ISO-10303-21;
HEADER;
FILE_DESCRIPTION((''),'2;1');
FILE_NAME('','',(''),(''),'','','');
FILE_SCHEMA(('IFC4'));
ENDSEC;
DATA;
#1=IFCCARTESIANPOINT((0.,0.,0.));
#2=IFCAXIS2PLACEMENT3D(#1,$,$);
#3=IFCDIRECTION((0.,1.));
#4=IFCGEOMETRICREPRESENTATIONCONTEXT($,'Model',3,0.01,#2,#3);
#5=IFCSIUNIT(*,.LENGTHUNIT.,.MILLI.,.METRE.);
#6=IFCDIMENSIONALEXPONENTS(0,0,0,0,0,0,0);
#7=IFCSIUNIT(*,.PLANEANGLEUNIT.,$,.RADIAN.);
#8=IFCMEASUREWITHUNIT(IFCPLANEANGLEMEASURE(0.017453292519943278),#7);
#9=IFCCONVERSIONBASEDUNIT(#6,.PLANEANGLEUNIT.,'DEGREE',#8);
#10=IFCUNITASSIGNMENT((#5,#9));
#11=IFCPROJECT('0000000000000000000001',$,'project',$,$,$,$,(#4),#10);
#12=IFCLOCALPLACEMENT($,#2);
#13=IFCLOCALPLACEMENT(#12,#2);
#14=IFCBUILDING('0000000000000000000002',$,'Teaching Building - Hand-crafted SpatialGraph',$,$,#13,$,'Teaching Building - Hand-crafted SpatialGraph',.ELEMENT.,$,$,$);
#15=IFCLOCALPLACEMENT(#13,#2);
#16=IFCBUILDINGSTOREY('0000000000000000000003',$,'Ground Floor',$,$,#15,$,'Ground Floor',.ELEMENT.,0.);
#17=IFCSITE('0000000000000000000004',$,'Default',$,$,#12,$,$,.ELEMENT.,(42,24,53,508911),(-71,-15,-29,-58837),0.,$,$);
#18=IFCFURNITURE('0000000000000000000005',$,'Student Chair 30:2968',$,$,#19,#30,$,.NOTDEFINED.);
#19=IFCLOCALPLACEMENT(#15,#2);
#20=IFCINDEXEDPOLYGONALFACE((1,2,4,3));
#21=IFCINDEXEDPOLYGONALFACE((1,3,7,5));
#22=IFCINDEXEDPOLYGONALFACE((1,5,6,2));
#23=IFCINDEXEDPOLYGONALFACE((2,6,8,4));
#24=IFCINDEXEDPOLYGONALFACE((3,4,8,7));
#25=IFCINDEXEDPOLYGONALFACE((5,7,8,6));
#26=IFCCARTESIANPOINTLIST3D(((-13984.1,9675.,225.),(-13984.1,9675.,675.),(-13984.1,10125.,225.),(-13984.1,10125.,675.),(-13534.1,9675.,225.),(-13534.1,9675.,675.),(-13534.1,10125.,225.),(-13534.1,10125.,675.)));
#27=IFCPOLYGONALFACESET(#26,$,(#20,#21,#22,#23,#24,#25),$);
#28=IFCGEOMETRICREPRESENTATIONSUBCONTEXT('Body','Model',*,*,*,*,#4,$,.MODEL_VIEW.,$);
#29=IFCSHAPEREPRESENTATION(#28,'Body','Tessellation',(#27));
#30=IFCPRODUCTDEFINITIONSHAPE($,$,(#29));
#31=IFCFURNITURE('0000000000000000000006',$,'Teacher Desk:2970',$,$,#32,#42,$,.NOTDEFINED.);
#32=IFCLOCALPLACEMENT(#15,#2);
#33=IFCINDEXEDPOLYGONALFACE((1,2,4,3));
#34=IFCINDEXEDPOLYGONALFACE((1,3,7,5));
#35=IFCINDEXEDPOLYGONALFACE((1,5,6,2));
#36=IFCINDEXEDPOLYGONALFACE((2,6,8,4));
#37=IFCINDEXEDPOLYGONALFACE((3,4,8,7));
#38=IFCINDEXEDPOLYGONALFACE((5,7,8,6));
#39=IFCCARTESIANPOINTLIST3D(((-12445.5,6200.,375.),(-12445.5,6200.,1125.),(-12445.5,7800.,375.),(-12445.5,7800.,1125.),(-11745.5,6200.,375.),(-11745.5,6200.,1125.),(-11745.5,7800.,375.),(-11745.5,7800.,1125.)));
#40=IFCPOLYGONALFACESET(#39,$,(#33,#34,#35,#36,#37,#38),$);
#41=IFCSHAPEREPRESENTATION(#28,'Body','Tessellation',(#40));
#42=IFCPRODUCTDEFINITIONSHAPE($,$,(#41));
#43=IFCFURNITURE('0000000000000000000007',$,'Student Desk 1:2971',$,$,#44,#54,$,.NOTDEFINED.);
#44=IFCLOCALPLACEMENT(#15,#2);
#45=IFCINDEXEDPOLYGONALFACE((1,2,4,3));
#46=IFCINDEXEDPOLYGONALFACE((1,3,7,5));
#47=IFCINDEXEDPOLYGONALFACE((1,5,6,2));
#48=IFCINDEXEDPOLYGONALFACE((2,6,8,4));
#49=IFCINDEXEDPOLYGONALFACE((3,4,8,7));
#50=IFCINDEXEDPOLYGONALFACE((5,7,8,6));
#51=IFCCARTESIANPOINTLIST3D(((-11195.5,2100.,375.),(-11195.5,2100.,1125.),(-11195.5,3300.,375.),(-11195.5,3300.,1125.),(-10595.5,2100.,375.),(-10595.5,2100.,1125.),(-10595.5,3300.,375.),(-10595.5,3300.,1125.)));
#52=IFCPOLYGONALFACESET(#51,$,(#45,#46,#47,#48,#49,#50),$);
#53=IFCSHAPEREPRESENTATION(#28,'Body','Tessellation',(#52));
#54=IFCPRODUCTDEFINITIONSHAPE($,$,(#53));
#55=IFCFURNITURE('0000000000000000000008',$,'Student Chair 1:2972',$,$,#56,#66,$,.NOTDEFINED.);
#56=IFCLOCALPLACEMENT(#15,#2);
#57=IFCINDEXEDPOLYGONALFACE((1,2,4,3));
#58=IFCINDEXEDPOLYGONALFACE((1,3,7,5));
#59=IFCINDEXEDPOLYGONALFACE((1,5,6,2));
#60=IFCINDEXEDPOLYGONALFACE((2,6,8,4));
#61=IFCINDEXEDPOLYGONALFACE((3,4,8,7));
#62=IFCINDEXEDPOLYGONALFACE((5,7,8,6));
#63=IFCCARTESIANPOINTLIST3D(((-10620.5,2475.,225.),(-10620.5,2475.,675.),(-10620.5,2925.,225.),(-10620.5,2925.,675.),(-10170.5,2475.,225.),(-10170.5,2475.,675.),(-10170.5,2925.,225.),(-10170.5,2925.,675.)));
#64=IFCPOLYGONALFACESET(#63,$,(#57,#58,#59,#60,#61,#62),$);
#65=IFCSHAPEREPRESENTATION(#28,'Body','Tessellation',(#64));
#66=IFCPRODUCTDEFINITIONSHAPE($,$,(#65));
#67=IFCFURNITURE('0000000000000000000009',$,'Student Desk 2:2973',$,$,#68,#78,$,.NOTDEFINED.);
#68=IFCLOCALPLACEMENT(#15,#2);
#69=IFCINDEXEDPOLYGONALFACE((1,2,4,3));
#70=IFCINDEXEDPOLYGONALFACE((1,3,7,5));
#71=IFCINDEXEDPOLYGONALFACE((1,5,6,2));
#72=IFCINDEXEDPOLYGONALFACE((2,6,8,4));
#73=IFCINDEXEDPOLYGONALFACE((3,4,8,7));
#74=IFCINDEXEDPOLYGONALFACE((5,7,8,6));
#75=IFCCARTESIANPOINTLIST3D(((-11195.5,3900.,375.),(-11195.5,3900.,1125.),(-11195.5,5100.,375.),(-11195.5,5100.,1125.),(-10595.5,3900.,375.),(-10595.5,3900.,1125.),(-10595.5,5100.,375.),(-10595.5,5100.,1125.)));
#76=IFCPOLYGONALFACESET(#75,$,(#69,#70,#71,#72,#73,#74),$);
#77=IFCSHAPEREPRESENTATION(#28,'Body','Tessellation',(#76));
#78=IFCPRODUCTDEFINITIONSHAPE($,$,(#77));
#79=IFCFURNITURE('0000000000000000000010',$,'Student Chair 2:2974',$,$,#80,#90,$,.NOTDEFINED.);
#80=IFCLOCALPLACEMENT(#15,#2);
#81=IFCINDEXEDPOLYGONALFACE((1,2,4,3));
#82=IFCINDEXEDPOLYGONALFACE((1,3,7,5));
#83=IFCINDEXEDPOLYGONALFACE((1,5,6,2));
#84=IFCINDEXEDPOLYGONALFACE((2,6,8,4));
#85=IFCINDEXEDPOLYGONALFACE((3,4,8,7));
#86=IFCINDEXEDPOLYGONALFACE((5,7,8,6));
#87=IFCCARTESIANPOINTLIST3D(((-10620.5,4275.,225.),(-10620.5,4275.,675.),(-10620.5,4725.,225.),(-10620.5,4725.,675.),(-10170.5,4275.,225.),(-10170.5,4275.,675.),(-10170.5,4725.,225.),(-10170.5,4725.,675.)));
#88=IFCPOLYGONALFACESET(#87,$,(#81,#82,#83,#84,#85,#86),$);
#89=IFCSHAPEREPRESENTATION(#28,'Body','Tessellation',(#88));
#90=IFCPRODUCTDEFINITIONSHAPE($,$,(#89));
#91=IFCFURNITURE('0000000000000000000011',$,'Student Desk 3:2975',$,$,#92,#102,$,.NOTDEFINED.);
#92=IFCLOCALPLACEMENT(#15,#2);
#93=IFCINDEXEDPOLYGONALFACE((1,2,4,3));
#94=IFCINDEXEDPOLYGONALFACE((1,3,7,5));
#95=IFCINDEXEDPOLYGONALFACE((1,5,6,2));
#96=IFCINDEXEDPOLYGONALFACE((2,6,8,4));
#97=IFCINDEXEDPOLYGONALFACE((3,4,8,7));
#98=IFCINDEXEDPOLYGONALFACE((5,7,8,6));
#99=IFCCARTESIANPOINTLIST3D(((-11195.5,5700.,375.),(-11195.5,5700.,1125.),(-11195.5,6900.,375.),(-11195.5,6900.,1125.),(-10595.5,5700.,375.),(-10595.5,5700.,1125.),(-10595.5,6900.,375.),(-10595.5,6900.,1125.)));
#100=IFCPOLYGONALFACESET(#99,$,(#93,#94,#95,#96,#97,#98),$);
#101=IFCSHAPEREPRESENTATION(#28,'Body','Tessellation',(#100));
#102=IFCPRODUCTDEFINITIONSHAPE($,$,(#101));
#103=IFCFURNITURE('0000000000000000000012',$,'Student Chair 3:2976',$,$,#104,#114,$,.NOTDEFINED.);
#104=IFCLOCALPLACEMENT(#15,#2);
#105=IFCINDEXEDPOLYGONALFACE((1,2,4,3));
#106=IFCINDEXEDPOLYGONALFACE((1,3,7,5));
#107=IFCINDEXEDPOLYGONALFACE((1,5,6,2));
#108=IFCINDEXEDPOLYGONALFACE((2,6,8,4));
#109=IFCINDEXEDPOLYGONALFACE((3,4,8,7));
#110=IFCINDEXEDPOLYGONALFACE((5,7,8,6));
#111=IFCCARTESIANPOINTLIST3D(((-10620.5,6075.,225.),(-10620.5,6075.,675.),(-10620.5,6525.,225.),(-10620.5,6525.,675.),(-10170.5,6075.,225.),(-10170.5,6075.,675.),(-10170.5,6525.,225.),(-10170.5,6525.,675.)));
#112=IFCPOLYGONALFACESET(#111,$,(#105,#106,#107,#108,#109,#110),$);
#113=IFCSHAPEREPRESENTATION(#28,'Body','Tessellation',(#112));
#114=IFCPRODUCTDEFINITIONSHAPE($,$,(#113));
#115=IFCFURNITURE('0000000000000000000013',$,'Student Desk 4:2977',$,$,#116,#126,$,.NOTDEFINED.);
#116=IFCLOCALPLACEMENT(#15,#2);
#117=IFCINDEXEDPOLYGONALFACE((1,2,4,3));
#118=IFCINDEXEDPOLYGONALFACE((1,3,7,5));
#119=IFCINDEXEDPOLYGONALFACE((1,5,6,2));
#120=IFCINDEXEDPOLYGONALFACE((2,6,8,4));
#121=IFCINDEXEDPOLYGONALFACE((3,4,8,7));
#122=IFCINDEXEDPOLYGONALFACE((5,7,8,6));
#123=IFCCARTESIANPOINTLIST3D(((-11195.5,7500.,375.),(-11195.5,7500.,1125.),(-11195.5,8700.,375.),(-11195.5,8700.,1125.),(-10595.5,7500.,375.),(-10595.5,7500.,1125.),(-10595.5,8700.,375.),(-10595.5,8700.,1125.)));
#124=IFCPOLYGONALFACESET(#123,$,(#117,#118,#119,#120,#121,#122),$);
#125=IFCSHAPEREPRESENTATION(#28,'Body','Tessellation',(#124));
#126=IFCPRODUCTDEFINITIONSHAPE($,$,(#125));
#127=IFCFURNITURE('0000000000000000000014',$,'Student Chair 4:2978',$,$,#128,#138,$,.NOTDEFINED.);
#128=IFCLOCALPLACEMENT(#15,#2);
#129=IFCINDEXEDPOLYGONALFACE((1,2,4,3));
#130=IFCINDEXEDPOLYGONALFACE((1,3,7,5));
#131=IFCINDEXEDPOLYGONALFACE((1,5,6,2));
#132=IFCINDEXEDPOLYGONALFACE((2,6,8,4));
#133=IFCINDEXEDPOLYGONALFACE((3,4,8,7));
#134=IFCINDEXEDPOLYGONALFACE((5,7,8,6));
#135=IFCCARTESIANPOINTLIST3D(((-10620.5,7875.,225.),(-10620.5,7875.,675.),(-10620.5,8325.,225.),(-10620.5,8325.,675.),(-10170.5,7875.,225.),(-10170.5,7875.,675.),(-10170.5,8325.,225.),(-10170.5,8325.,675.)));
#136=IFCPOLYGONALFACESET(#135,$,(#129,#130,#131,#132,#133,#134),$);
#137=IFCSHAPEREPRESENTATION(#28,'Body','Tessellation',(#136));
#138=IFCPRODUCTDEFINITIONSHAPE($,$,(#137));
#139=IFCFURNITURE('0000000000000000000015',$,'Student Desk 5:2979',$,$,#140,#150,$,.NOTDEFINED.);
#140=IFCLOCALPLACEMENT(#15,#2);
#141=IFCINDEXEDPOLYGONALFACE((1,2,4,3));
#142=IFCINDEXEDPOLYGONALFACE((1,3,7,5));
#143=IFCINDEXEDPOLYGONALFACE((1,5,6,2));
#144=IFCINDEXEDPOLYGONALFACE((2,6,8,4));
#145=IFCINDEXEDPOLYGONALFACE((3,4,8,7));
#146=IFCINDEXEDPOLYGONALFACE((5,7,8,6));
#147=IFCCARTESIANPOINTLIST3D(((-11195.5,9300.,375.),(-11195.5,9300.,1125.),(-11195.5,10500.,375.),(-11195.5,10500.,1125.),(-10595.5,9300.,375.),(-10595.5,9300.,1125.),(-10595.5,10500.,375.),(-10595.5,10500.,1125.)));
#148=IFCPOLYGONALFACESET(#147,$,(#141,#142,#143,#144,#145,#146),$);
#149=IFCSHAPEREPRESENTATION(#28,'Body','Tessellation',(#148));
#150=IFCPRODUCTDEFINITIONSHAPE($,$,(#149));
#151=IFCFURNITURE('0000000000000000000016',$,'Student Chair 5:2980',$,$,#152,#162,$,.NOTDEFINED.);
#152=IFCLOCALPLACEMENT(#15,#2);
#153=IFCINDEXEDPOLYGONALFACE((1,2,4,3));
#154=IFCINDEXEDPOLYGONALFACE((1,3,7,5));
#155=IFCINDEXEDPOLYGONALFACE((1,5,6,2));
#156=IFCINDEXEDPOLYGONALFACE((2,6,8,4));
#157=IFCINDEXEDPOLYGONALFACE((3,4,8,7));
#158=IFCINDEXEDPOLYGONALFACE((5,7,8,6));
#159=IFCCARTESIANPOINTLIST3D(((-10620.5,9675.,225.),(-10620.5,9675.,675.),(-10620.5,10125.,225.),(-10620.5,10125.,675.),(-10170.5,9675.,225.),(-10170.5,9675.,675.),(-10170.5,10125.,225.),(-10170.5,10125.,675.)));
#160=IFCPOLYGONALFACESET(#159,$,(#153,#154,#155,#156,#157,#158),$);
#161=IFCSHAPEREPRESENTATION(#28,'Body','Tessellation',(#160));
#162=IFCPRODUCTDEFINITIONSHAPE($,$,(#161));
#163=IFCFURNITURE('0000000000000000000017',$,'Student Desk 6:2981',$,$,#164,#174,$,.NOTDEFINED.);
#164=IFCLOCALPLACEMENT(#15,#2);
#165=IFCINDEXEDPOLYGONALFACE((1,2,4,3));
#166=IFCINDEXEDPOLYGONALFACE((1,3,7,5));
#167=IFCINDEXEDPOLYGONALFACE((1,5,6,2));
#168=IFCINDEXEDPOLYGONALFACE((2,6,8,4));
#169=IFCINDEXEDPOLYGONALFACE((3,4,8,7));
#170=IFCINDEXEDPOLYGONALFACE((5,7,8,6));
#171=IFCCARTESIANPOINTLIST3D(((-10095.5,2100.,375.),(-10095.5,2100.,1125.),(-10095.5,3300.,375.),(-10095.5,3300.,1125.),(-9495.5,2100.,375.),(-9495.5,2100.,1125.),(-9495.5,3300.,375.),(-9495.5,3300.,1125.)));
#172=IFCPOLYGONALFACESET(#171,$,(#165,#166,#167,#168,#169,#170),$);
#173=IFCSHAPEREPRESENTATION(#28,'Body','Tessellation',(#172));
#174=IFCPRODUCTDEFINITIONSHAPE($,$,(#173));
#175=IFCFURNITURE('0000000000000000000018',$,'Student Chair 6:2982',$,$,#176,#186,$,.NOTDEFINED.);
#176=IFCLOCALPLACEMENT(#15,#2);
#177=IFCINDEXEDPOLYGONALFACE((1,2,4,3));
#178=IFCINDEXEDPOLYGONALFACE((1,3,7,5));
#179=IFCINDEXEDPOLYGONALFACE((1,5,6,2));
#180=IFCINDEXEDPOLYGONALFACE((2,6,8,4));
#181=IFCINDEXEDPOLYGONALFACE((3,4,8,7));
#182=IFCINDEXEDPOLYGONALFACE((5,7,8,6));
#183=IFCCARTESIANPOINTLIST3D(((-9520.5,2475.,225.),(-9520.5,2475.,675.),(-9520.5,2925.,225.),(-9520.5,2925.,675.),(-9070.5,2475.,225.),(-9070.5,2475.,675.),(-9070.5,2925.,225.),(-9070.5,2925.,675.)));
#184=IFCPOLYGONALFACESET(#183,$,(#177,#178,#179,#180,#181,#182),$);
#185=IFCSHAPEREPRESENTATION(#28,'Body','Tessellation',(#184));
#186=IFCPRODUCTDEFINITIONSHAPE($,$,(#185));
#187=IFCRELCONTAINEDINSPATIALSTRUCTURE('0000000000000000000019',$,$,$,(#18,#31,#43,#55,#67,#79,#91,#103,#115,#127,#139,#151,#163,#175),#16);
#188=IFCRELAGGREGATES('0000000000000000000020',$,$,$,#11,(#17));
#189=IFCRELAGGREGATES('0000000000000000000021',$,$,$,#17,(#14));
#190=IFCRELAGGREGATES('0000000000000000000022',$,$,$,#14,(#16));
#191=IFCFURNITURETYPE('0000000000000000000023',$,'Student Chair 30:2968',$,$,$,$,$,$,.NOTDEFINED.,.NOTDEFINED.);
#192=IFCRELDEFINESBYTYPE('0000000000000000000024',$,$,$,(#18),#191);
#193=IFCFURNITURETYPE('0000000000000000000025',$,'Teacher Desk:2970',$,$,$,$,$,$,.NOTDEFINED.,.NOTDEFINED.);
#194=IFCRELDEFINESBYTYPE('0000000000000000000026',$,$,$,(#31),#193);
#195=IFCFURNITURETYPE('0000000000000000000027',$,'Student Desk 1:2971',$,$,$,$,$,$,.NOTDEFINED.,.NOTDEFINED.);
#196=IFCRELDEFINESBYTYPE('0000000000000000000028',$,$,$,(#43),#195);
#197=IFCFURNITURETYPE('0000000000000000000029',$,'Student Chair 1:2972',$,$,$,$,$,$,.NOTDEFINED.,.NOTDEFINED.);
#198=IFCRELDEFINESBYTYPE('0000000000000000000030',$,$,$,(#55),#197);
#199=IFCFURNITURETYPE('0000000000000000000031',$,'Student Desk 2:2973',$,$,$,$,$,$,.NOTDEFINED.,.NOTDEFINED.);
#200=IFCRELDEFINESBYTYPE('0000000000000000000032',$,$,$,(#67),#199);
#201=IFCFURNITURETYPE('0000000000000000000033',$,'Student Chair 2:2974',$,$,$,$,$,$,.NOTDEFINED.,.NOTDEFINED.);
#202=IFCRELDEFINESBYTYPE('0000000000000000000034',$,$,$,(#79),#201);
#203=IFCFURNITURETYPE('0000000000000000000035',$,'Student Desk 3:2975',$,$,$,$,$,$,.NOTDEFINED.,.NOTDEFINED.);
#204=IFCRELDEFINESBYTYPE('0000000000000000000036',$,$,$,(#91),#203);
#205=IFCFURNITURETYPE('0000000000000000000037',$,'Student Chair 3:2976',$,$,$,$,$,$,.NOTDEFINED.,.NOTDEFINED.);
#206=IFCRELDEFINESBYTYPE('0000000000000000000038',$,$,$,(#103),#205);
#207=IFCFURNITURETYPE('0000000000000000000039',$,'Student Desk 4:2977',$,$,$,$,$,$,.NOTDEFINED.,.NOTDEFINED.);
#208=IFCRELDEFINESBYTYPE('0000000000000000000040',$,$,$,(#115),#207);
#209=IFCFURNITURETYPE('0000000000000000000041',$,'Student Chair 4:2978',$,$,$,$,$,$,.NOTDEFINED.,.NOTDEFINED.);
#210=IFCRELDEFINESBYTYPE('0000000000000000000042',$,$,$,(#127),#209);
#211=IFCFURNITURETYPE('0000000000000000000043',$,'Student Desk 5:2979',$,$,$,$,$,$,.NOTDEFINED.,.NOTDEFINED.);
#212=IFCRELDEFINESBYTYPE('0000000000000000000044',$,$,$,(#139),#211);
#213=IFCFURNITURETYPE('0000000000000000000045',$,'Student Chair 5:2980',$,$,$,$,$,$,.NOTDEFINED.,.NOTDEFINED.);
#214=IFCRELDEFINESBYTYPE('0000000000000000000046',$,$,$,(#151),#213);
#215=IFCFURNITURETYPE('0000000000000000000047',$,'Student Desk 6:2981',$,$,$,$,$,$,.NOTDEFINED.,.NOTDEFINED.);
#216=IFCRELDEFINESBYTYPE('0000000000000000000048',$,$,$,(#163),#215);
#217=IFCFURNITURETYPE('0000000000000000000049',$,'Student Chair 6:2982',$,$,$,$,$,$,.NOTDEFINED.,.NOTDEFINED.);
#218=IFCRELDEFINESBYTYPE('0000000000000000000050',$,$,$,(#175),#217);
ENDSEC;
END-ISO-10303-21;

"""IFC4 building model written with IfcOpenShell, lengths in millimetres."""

from ifc_helpers import new_model, entity, si_unit, converted_unit, direction, frame, frame_2d, origin, origin_2d_with_axis, place, context, subcontext, project, spatial, rectangle, extrude, type_object, element, save


model = new_model("IFC4")

# Units and contexts
model_context = context("Model", 3, precision=0.01, world=origin(), true_north=direction((0.0, 1.0)))
body_context = subcontext(model_context, "Body", "Model", "MODEL_VIEW")
ifc_project = project(units=[si_unit("LENGTHUNIT", "METRE", prefix="MILLI"), converted_unit("PLANEANGLEUNIT", "DEGREE", entity("IfcPlaneAngleMeasure", 0.017453292519943278), si_unit("PLANEANGLEUNIT", "RADIAN"), dimensions=[0, 0, 0, 0, 0, 0, 0])], contexts=[model_context])

# Site, building, storey
site_placement = place(None, origin())
site = spatial("IfcSite", under=ifc_project, at=site_placement, Name="Default", CompositionType="ELEMENT", RefLatitude=(42, 24, 53, 508911), RefLongitude=(-71, -15, -29, -58837), RefElevation=0.0)
building_placement = place(site_placement, origin())
building = spatial("IfcBuilding", under=site, at=building_placement, Name="Teaching Building - Hand-crafted SpatialGraph", LongName="Teaching Building - Hand-crafted SpatialGraph", CompositionType="ELEMENT")
storey_placement = place(building_placement, origin())
storey = spatial("IfcBuildingStorey", under=building, at=storey_placement, Name="Ground Floor", LongName="Ground Floor", CompositionType="ELEMENT", Elevation=0.0)

# Furniture
furniture_type_1 = type_object("IfcFurnitureType", Name="Student Chair 30:2968", PredefinedType="NOTDEFINED")
furniture_1_placement = place(storey_placement, origin())
element("IfcFurniture", 1, at=furniture_1_placement, inside=storey, type_object=furniture_type_1, Name="Student Chair 30:2968", PredefinedType="NOTDEFINED", context=body_context, shape_type="SweptSolid", body=[
    extrude(rectangle(XDim=450.0, YDim=450.0, at=frame_2d((0.0, 0.0), x_axis=(1.0, 0.0))), frame((-13759.1, 9900.0, 225.0)), (0.0, 0.0, 1.0), 450.0),
])
furniture_type_2 = type_object("IfcFurnitureType", Name="Teacher Desk:2970", PredefinedType="NOTDEFINED")
furniture_2_placement = place(storey_placement, origin())
element("IfcFurniture", 2, at=furniture_2_placement, inside=storey, type_object=furniture_type_2, Name="Teacher Desk:2970", PredefinedType="NOTDEFINED", context=body_context, shape_type="SweptSolid", body=[
    extrude(rectangle(XDim=1600.0, YDim=700.0, at=origin_2d_with_axis()), frame((-12095.5, 7000.0, 375.0), z_axis=(0.0, 0.0, 1.0), x_axis=(0.0, 1.0, 0.0)), (0.0, 0.0, 1.0), 750.0),
])
furniture_type_3 = type_object("IfcFurnitureType", Name="Student Desk 1:2971", PredefinedType="NOTDEFINED")
furniture_3_placement = place(storey_placement, origin())
element("IfcFurniture", 3, at=furniture_3_placement, inside=storey, type_object=furniture_type_3, Name="Student Desk 1:2971", PredefinedType="NOTDEFINED", context=body_context, shape_type="SweptSolid", body=[
    extrude(rectangle(XDim=1200.0, YDim=600.0, at=origin_2d_with_axis()), frame((-10895.5, 2700.0, 375.0), z_axis=(0.0, 0.0, 1.0), x_axis=(0.0, 1.0, 0.0)), (0.0, 0.0, 1.0), 750.0),
])
furniture_type_4 = type_object("IfcFurnitureType", Name="Student Chair 1:2972", PredefinedType="NOTDEFINED")
furniture_4_placement = place(storey_placement, origin())
element("IfcFurniture", 4, at=furniture_4_placement, inside=storey, type_object=furniture_type_4, Name="Student Chair 1:2972", PredefinedType="NOTDEFINED", context=body_context, shape_type="SweptSolid", body=[
    extrude(rectangle(XDim=450.0, YDim=450.0, at=origin_2d_with_axis()), frame((-10395.5, 2700.0, 225.0)), (0.0, 0.0, 1.0), 450.0),
])
furniture_type_5 = type_object("IfcFurnitureType", Name="Student Desk 2:2973", PredefinedType="NOTDEFINED")
furniture_5_placement = place(storey_placement, origin())
element("IfcFurniture", 5, at=furniture_5_placement, inside=storey, type_object=furniture_type_5, Name="Student Desk 2:2973", PredefinedType="NOTDEFINED", context=body_context, shape_type="SweptSolid", body=[
    extrude(rectangle(XDim=1200.0, YDim=600.0, at=frame_2d((0.0, 0.0), x_axis=(1.0, 0.0))), frame((-10895.5, 4500.0, 375.0), z_axis=(0.0, 0.0, 1.0), x_axis=(0.0, 1.0, 0.0)), (0.0, 0.0, 1.0), 750.0),
])
furniture_type_6 = type_object("IfcFurnitureType", Name="Student Chair 2:2974", PredefinedType="NOTDEFINED")
furniture_6_placement = place(storey_placement, origin())
element("IfcFurniture", 6, at=furniture_6_placement, inside=storey, type_object=furniture_type_6, Name="Student Chair 2:2974", PredefinedType="NOTDEFINED", context=body_context, shape_type="SweptSolid", body=[
    extrude(rectangle(XDim=450.0, YDim=450.0, at=origin_2d_with_axis()), frame((-10395.5, 4500.0, 225.0)), (0.0, 0.0, 1.0), 450.0),
])
furniture_type_7 = type_object("IfcFurnitureType", Name="Student Desk 3:2975", PredefinedType="NOTDEFINED")
furniture_7_placement = place(storey_placement, origin())
element("IfcFurniture", 7, at=furniture_7_placement, inside=storey, type_object=furniture_type_7, Name="Student Desk 3:2975", PredefinedType="NOTDEFINED", context=body_context, shape_type="SweptSolid", body=[
    extrude(rectangle(XDim=1200.0, YDim=600.0, at=origin_2d_with_axis()), frame((-10895.5, 6300.0, 375.0), z_axis=(0.0, 0.0, 1.0), x_axis=(0.0, 1.0, 0.0)), (0.0, 0.0, 1.0), 750.0),
])
furniture_type_8 = type_object("IfcFurnitureType", Name="Student Chair 3:2976", PredefinedType="NOTDEFINED")
furniture_8_placement = place(storey_placement, origin())
element("IfcFurniture", 8, at=furniture_8_placement, inside=storey, type_object=furniture_type_8, Name="Student Chair 3:2976", PredefinedType="NOTDEFINED", context=body_context, shape_type="SweptSolid", body=[
    extrude(rectangle(XDim=450.0, YDim=450.0, at=origin_2d_with_axis()), frame((-10395.5, 6300.0, 225.0)), (0.0, 0.0, 1.0), 450.0),
])
furniture_type_9 = type_object("IfcFurnitureType", Name="Student Desk 4:2977", PredefinedType="NOTDEFINED")
furniture_9_placement = place(storey_placement, origin())
element("IfcFurniture", 9, at=furniture_9_placement, inside=storey, type_object=furniture_type_9, Name="Student Desk 4:2977", PredefinedType="NOTDEFINED", context=body_context, shape_type="SweptSolid", body=[
    extrude(rectangle(XDim=1200.0, YDim=600.0, at=origin_2d_with_axis()), frame((-10895.5, 8100.0, 375.0), z_axis=(0.0, 0.0, 1.0), x_axis=(0.0, 1.0, 0.0)), (0.0, 0.0, 1.0), 750.0),
])
furniture_type_10 = type_object("IfcFurnitureType", Name="Student Chair 4:2978", PredefinedType="NOTDEFINED")
furniture_10_placement = place(storey_placement, origin())
element("IfcFurniture", 10, at=furniture_10_placement, inside=storey, type_object=furniture_type_10, Name="Student Chair 4:2978", PredefinedType="NOTDEFINED", context=body_context, shape_type="SweptSolid", body=[
    extrude(rectangle(XDim=450.0, YDim=450.0, at=origin_2d_with_axis()), frame((-10395.5, 8100.0, 225.0)), (0.0, 0.0, 1.0), 450.0),
])
furniture_type_11 = type_object("IfcFurnitureType", Name="Student Desk 5:2979", PredefinedType="NOTDEFINED")
furniture_11_placement = place(storey_placement, origin())
element("IfcFurniture", 11, at=furniture_11_placement, inside=storey, type_object=furniture_type_11, Name="Student Desk 5:2979", PredefinedType="NOTDEFINED", context=body_context, shape_type="SweptSolid", body=[
    extrude(rectangle(XDim=1200.0, YDim=600.0, at=origin_2d_with_axis()), frame((-10895.5, 9900.0, 375.0), z_axis=(0.0, 0.0, 1.0), x_axis=(0.0, 1.0, 0.0)), (0.0, 0.0, 1.0), 750.0),
])
furniture_type_12 = type_object("IfcFurnitureType", Name="Student Chair 5:2980", PredefinedType="NOTDEFINED")
furniture_12_placement = place(storey_placement, origin())
element("IfcFurniture", 12, at=furniture_12_placement, inside=storey, type_object=furniture_type_12, Name="Student Chair 5:2980", PredefinedType="NOTDEFINED", context=body_context, shape_type="SweptSolid", body=[
    extrude(rectangle(XDim=450.0, YDim=450.0, at=frame_2d((0.0, 0.0), x_axis=(1.0, 0.0))), frame((-10395.5, 9900.0, 225.0)), (0.0, 0.0, 1.0), 450.0),
])
furniture_type_13 = type_object("IfcFurnitureType", Name="Student Desk 6:2981", PredefinedType="NOTDEFINED")
furniture_13_placement = place(storey_placement, origin())
element("IfcFurniture", 13, at=furniture_13_placement, inside=storey, type_object=furniture_type_13, Name="Student Desk 6:2981", PredefinedType="NOTDEFINED", context=body_context, shape_type="SweptSolid", body=[
    extrude(rectangle(XDim=1200.0, YDim=600.0, at=frame_2d((0.0, 0.0), x_axis=(1.0, 0.0))), frame((-9795.5, 2700.0, 375.0), z_axis=(0.0, 0.0, 1.0), x_axis=(0.0, 1.0, 0.0)), (0.0, 0.0, 1.0), 750.0),
])
furniture_type_14 = type_object("IfcFurnitureType", Name="Student Chair 6:2982", PredefinedType="NOTDEFINED")
furniture_14_placement = place(storey_placement, origin())
element("IfcFurniture", 14, at=furniture_14_placement, inside=storey, type_object=furniture_type_14, Name="Student Chair 6:2982", PredefinedType="NOTDEFINED", context=body_context, shape_type="SweptSolid", body=[
    extrude(rectangle(XDim=450.0, YDim=450.0, at=origin_2d_with_axis()), frame((-9295.5, 2700.0, 225.0)), (0.0, 0.0, 1.0), 450.0),
])

save(model, "model.ifc")
